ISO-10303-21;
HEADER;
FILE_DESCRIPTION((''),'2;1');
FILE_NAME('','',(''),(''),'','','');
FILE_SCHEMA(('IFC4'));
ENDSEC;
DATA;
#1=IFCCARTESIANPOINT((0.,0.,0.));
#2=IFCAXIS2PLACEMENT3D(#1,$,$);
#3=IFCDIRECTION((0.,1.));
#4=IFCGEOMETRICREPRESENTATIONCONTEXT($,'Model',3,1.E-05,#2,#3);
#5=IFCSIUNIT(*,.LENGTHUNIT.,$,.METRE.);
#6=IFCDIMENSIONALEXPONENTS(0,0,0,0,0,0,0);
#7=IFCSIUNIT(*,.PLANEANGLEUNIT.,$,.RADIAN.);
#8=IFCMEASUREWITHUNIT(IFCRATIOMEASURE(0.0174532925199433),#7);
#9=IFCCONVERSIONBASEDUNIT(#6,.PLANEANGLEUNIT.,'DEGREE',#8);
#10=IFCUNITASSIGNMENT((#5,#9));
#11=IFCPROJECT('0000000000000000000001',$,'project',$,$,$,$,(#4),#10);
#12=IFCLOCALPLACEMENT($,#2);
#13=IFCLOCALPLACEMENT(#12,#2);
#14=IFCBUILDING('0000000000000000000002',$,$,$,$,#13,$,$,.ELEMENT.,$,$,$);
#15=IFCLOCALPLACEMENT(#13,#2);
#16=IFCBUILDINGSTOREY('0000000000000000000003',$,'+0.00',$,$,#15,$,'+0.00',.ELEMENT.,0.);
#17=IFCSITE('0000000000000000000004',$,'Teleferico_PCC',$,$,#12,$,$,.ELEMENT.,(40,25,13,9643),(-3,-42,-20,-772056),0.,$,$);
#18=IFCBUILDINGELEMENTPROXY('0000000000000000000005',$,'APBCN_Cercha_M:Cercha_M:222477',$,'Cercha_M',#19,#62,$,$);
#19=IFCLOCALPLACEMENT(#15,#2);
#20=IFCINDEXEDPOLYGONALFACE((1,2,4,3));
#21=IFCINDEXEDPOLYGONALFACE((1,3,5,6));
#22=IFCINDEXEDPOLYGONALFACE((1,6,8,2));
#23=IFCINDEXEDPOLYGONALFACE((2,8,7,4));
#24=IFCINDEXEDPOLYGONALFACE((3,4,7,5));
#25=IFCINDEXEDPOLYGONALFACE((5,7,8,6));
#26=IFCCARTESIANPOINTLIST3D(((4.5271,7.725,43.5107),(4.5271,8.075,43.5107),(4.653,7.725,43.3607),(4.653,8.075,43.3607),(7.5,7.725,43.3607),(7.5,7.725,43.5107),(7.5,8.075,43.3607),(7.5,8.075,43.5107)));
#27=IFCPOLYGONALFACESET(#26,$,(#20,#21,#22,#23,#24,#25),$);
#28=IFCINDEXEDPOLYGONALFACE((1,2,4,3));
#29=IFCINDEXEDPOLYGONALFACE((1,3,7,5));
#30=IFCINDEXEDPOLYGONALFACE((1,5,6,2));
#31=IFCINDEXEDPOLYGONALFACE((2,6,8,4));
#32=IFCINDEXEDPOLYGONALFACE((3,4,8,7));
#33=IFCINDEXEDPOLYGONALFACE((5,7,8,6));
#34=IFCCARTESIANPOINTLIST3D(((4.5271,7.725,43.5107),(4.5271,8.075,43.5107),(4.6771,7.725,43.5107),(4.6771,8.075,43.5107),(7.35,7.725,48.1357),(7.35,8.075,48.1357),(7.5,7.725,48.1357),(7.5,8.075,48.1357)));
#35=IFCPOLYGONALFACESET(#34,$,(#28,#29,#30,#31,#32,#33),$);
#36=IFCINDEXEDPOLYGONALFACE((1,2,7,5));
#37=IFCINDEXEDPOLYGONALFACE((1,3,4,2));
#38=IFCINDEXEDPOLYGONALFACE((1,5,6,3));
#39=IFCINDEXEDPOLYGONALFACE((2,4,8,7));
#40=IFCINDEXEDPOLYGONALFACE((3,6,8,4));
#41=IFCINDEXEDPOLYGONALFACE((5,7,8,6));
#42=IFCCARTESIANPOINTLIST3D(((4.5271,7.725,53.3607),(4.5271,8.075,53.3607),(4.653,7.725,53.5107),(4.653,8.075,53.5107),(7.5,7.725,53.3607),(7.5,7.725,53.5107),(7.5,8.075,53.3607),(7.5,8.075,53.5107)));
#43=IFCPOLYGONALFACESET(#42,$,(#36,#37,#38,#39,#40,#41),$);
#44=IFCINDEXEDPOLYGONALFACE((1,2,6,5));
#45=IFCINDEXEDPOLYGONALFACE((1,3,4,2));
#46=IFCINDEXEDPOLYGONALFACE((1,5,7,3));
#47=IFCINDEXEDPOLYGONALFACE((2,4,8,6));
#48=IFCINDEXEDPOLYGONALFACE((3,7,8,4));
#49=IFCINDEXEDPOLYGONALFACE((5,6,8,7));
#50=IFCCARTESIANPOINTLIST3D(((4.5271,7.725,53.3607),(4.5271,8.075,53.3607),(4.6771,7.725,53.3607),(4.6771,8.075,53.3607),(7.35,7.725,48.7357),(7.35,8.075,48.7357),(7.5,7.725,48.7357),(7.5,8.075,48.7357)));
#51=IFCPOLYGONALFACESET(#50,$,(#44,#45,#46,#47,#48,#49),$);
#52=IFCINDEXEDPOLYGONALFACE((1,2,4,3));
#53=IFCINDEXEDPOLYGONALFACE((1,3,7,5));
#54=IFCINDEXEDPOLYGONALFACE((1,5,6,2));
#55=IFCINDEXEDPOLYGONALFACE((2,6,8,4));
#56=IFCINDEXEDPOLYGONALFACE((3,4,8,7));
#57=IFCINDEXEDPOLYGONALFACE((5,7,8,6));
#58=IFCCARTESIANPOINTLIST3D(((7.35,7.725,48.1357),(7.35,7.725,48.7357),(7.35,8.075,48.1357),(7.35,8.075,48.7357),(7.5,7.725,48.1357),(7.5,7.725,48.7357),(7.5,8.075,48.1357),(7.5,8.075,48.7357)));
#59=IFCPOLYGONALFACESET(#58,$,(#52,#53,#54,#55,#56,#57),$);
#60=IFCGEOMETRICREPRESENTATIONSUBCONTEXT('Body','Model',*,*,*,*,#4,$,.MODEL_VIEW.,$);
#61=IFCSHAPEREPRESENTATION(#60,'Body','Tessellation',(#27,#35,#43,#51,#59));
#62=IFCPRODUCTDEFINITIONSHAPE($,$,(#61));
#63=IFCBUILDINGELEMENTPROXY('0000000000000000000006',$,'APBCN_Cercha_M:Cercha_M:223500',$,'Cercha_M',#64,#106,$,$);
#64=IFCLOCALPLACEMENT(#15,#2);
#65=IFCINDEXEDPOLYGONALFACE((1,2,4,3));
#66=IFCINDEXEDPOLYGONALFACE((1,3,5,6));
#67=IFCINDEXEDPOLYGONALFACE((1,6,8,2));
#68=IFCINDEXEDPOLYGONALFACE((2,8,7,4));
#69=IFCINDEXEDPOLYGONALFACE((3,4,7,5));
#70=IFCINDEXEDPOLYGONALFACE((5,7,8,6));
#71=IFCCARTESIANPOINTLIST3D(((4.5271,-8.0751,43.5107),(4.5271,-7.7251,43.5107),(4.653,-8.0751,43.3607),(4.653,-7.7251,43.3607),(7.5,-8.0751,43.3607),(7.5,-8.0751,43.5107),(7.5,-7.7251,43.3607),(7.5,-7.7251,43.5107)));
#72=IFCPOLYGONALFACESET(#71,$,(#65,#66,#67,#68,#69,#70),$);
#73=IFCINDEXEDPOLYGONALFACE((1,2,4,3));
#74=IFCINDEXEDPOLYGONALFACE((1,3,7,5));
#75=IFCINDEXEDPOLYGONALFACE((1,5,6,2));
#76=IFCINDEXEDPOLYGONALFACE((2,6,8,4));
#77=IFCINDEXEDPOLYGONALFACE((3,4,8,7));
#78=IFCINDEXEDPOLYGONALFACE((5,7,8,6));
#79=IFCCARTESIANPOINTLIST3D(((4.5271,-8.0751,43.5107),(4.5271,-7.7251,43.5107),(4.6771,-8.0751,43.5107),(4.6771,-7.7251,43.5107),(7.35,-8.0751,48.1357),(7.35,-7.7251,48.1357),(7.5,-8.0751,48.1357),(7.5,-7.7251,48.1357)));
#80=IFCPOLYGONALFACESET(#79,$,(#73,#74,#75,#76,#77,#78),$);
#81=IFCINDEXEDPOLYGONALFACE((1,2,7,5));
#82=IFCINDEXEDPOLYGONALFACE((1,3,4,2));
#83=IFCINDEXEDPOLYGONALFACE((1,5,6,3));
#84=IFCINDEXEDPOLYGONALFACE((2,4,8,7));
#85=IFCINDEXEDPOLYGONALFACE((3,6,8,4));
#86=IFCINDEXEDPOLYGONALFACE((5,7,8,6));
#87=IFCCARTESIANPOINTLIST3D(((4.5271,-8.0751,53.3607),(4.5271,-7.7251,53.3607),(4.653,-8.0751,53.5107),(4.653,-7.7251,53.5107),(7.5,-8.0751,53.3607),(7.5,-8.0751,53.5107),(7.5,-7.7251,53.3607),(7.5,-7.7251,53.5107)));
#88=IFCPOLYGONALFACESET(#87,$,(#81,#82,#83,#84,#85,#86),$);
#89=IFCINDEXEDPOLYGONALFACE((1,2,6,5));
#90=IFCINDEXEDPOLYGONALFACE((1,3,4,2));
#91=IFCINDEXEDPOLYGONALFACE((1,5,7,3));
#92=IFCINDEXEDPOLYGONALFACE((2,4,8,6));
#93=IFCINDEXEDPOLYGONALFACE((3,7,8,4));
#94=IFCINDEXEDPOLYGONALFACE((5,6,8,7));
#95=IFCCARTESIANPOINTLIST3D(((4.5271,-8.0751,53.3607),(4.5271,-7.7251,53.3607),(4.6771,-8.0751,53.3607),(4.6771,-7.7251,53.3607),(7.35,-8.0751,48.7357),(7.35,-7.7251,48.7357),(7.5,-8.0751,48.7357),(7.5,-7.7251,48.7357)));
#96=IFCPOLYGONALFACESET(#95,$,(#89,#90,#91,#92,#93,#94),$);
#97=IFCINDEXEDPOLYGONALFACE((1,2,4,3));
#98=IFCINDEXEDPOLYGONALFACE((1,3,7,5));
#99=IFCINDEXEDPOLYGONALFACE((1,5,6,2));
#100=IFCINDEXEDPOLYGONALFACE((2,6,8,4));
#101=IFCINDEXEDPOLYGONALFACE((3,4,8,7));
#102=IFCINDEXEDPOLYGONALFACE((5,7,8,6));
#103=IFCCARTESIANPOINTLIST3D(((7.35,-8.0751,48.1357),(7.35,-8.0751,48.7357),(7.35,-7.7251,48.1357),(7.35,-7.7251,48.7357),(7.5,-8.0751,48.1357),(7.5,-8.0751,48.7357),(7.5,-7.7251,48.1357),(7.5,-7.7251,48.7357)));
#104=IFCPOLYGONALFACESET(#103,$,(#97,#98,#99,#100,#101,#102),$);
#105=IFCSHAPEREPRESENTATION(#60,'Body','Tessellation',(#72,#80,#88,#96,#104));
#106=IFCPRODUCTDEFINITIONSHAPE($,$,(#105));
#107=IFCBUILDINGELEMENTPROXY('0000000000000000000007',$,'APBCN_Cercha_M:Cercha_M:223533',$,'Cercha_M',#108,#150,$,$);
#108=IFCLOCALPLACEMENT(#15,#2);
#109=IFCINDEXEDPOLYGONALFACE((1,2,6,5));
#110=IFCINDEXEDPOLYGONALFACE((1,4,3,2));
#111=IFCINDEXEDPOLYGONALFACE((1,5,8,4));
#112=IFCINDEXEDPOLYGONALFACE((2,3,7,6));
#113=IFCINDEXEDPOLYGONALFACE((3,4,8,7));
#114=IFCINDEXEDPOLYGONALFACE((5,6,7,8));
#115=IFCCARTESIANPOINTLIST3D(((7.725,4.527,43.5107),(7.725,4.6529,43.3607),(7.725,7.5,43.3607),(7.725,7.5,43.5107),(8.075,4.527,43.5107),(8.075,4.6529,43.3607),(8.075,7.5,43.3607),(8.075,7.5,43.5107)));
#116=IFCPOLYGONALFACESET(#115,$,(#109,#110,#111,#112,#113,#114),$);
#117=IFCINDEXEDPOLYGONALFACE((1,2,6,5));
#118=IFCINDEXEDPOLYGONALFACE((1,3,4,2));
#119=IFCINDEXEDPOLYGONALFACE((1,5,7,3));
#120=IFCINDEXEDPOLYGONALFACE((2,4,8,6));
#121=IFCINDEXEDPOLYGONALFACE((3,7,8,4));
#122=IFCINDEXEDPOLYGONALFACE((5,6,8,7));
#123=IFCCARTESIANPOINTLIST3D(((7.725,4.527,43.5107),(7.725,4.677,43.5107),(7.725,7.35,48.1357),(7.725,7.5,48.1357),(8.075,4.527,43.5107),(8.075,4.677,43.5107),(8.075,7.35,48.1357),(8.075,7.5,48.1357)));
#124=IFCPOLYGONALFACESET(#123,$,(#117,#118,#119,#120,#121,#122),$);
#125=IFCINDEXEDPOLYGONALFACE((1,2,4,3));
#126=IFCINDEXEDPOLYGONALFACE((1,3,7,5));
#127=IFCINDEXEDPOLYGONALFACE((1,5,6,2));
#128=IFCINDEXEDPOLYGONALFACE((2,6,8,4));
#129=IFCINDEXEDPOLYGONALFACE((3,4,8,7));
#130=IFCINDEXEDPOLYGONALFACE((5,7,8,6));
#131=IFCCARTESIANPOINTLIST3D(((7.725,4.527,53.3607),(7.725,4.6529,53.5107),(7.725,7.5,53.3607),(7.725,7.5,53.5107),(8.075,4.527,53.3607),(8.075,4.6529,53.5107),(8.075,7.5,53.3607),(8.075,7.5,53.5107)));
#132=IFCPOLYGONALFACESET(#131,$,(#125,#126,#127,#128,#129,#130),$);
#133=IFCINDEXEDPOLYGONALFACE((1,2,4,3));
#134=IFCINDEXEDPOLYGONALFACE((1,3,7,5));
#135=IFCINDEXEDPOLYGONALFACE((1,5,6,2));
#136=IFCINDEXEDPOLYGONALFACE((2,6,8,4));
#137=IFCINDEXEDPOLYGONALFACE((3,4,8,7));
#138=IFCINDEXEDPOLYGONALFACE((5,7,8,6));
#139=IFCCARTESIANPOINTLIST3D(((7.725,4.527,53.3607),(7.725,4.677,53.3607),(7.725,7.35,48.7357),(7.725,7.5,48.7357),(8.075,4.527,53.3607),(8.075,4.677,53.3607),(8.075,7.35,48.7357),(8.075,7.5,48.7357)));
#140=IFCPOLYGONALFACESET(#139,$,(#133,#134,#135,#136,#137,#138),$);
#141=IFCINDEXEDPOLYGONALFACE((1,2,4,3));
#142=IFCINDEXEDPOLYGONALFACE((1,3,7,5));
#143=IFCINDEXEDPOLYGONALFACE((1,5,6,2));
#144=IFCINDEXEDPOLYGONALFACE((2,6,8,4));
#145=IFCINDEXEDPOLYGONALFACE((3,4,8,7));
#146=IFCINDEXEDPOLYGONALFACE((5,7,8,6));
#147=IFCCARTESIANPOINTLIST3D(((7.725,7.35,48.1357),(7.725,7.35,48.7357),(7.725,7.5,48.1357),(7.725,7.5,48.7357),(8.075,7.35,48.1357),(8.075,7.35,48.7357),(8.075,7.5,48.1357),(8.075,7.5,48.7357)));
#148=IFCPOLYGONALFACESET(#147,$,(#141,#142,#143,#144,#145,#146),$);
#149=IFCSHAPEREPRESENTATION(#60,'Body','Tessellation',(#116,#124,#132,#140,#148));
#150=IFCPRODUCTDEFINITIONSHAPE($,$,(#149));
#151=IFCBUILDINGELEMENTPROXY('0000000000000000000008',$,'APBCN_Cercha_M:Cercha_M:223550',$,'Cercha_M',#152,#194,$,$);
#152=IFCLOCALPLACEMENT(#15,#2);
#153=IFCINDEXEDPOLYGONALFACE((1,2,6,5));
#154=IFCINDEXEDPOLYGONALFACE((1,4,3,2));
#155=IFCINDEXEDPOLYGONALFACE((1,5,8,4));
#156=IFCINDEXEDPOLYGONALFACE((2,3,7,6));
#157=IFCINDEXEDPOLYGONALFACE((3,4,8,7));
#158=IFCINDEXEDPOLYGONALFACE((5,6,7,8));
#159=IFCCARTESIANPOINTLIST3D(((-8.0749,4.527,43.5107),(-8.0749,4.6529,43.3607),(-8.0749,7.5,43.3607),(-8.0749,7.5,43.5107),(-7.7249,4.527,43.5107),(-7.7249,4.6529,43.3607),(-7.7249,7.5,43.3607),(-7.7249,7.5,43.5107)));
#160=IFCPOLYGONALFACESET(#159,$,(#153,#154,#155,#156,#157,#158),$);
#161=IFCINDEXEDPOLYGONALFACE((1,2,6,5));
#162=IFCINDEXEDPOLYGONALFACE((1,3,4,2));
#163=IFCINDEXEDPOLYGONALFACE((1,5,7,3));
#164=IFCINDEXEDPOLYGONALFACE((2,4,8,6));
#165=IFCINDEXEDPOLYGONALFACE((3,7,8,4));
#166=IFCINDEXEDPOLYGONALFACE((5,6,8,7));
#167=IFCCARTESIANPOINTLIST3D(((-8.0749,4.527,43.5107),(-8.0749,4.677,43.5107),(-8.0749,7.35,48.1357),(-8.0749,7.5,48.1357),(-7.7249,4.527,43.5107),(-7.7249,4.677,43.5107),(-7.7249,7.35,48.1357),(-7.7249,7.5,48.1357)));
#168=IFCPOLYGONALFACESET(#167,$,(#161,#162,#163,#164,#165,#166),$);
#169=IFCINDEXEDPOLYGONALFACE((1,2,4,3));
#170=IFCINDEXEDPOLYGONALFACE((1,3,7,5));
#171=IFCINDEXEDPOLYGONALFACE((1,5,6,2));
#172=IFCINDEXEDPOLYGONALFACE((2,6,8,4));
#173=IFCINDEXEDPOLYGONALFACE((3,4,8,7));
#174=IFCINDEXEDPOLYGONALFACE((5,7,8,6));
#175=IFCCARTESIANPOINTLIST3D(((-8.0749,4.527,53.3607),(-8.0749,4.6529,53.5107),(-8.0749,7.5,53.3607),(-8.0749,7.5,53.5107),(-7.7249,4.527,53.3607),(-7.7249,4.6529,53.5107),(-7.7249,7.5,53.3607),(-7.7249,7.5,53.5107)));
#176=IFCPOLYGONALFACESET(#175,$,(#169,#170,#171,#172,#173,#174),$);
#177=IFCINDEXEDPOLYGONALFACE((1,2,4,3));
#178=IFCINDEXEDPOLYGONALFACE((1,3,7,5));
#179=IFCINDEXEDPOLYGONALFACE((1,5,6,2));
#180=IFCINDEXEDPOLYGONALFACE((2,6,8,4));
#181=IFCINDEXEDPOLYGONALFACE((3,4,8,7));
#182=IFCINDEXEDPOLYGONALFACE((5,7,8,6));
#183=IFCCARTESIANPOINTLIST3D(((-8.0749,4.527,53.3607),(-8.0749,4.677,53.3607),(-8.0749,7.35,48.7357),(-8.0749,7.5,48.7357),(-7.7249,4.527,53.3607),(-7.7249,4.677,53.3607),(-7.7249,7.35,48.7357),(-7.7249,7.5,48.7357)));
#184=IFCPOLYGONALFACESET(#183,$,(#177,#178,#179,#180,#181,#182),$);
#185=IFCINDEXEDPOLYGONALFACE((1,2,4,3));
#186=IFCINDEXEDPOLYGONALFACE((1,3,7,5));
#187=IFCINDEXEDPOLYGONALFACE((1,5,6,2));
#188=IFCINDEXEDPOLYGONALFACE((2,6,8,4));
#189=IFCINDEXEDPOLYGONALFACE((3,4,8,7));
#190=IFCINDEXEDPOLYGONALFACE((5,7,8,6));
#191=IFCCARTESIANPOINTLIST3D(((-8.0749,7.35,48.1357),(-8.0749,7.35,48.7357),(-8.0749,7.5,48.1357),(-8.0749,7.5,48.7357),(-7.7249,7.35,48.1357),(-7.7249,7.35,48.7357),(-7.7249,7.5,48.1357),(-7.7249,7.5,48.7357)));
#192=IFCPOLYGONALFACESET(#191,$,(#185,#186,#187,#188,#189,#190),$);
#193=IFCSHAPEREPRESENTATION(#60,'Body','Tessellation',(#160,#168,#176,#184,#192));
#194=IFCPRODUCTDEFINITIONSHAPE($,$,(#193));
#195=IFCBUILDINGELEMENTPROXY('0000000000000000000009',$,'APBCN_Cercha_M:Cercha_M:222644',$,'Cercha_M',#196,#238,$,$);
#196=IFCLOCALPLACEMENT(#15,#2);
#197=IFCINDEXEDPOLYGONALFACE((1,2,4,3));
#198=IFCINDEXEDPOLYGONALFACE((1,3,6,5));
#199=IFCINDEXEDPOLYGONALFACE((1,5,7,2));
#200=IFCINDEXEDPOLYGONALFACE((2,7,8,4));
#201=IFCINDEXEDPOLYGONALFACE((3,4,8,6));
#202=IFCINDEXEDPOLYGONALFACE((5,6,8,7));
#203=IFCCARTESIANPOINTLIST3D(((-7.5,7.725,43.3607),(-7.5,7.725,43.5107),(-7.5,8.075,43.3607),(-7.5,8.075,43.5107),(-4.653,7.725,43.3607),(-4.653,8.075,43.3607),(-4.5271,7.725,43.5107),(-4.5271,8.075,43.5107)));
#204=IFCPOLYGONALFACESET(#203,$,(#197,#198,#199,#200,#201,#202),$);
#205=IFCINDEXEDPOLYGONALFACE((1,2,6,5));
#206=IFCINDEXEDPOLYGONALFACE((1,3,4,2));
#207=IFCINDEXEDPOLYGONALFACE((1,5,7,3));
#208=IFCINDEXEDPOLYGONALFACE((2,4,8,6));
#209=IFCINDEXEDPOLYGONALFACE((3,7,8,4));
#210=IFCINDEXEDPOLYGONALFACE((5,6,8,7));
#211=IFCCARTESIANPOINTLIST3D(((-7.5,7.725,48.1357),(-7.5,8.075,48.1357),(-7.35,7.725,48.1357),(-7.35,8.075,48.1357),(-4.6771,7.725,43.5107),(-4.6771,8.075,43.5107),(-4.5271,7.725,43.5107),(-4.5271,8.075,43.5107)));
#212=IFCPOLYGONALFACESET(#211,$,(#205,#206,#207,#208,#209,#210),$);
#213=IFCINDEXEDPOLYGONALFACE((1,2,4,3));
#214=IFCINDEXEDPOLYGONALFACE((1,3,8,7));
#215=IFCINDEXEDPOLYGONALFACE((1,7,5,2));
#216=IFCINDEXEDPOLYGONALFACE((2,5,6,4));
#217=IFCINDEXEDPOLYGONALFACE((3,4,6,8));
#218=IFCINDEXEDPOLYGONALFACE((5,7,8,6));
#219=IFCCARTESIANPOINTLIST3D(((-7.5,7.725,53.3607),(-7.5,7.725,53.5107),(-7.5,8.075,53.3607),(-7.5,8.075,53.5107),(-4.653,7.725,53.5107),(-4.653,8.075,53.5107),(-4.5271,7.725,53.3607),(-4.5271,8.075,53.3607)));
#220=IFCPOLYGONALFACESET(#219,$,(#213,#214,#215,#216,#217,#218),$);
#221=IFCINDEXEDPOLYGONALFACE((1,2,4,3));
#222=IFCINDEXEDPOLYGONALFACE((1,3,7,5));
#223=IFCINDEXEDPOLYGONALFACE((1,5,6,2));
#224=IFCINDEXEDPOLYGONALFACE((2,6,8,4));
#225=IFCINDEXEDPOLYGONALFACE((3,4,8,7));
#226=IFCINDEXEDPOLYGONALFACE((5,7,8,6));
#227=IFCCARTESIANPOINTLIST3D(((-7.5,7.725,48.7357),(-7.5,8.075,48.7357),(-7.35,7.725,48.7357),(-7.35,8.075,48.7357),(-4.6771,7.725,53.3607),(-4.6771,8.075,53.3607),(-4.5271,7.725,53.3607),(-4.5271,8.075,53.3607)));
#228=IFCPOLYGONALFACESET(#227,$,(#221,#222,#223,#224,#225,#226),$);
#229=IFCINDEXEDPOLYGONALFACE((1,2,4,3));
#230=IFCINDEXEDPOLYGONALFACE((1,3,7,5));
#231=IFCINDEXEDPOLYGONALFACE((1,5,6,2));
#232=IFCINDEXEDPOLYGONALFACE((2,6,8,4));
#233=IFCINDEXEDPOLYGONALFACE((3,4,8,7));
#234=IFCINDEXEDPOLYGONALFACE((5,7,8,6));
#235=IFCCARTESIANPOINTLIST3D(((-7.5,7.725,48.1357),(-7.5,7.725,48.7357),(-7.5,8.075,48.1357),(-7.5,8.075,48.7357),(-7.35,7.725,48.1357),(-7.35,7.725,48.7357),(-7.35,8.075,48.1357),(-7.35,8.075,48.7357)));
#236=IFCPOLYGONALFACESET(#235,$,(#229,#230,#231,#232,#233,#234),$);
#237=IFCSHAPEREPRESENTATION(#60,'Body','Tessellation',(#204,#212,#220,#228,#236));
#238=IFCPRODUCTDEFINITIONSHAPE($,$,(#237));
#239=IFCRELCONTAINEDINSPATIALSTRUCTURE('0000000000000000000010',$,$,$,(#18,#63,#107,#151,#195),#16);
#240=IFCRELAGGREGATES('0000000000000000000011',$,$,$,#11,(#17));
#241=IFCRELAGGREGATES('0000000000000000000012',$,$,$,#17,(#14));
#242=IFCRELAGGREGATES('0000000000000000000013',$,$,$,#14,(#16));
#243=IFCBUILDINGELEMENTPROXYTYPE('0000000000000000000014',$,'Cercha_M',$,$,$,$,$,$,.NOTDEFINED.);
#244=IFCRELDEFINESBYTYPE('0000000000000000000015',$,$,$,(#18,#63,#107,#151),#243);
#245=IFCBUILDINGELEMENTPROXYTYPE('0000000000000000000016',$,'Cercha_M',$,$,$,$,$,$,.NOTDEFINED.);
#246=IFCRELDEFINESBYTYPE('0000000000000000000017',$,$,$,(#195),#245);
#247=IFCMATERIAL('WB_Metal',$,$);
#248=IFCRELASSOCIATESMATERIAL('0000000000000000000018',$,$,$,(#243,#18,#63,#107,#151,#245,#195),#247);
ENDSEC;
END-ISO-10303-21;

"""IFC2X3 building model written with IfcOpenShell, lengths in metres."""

from ifc_helpers import new_model, entity, si_unit, converted_unit, direction, frame, origin, origin_2d_with_axis, place, context, subcontext, project, spatial, polyline, rectangle, outline, extrude, source, transform, mapped, material, type_object, type_shapes, element, save


model = new_model("IFC2X3")

# Units and contexts
model_context = context("Model", 3, precision=1e-05, world=origin(), true_north=direction((0.0, 1.0)))
body_context = subcontext(model_context, "Body", "Model", "MODEL_VIEW")
ifc_project = project(units=[si_unit("LENGTHUNIT", "METRE"), converted_unit("PLANEANGLEUNIT", "DEGREE", entity("IfcRatioMeasure", 0.0174532925199433), si_unit("PLANEANGLEUNIT", "RADIAN"), dimensions=[0, 0, 0, 0, 0, 0, 0])], contexts=[model_context])

# Site, building, storey
site_placement = place(None, origin())
site = spatial("IfcSite", under=ifc_project, at=site_placement, Name="Teleferico_PCC", CompositionType="ELEMENT", RefLatitude=(40, 25, 13, 9643), RefLongitude=(-3, -42, -20, -772056), RefElevation=0.0)
building_placement = place(site_placement, origin())
building = spatial("IfcBuilding", under=site, at=building_placement, CompositionType="ELEMENT")
storey_placement = place(building_placement, origin())
storey = spatial("IfcBuildingStorey", under=building, at=storey_placement, Name="+0.00", LongName="+0.00", CompositionType="ELEMENT", Elevation=0.0)

# Shared definitions
ifc_material_1 = material(Name="WB_Metal")

# Building element proxies
building_element_proxy_type_1 = type_object("IfcBuildingElementProxyType", Name="Cercha_M", PredefinedType="NOTDEFINED", material=ifc_material_1)
shared_shape_1 = source(origin(), body_context, "Body", "SweptSolid", [
    extrude(outline(polyline([(-1.455, -0.075), (1.3921, -0.075), (1.5179, 0.075), (-1.455, 0.075), (-1.455, -0.075)])), frame((-1.455, -0.175, -5.0), z_axis=(0.0, 1.0, 0.0), x_axis=(-1.0, 0.0, 0.0)), (0.0, 0.0, 1.0), 0.35),
    extrude(outline(polyline([(1.3365, -2.3125), (1.4865, -2.3125), (-1.3365, 2.3125), (-1.4865, 2.3125), (1.3365, -2.3125)])), frame((-1.4865, -0.175, -2.6125), z_axis=(0.0, 1.0, 0.0), x_axis=(1.0, 0.0, 0.0)), (0.0, 0.0, 1.0), 0.35),
    extrude(outline(polyline([(-1.455, -0.075), (1.5179, -0.075), (1.3921, 0.075), (-1.455, 0.075), (-1.455, -0.075)])), frame((-1.455, -0.175, 5.0), z_axis=(0.0, 1.0, 0.0), x_axis=(-1.0, 0.0, 0.0)), (0.0, 0.0, 1.0), 0.35),
    extrude(outline(polyline([(-2.6701, -0.064), (2.7483, -0.064), (2.6701, 0.064), (-2.7483, 0.064), (-2.6701, -0.064)])), frame((-1.4865, -0.175, 2.6125), z_axis=(0.0, 1.0, 0.0), x_axis=(-0.520985, 0.0, 0.853566)), (0.0, 0.0, 1.0), 0.35),
    extrude(rectangle(XDim=0.35, YDim=0.15, at=origin_2d_with_axis()), frame((-0.075, 0.0, -0.3), z_axis=(0.0, 0.0, 1.0), x_axis=(0.0, 1.0, 0.0)), (0.0, 0.0, 1.0), 0.6),
])
type_shapes(building_element_proxy_type_1, [shared_shape_1])
for number, where, name in (
    (1, (7.5, 7.9, 48.4357), "APBCN_Cercha_M:Cercha_M:222477"),
    (2, (7.5, -7.9001, 48.4357), "APBCN_Cercha_M:Cercha_M:223500"),
):
    element("IfcBuildingElementProxy", number, at=place(storey_placement, frame(where)), inside=storey, type_object=building_element_proxy_type_1, material=ifc_material_1, Name=name, ObjectType="Cercha_M", context=body_context, shape_type="MappedRepresentation", body=[
        mapped(shared_shape_1, transform((0.0, 0.0, 0.0), scale=1.0)),
    ])
for number, where, z_axis, x_axis, name in (
    (3, (7.9, 7.5, 48.4357), (0.0, 0.0, 1.0), (0.0, 1.0, 0.0), "APBCN_Cercha_M:Cercha_M:223533"),
    (4, (-7.8999, 7.5, 48.4357), (0.0, 0.0, 1.0), (0.0, 1.0, 0.0), "APBCN_Cercha_M:Cercha_M:223550"),
):
    element("IfcBuildingElementProxy", number, at=place(storey_placement, frame(where, z_axis=z_axis, x_axis=x_axis)), inside=storey, type_object=building_element_proxy_type_1, material=ifc_material_1, Name=name, ObjectType="Cercha_M", context=body_context, shape_type="MappedRepresentation", body=[
        mapped(shared_shape_1, transform((0.0, 0.0, 0.0), scale=1.0)),
    ])
building_element_proxy_type_2 = type_object("IfcBuildingElementProxyType", Name="Cercha_M", PredefinedType="NOTDEFINED", material=ifc_material_1)
shared_shape_2 = source(origin(), body_context, "Body", "SweptSolid", [
    extrude(outline(polyline([(-0.075, -1.455), (0.075, -1.455), (0.075, 1.3921), (-0.075, 1.5179), (-0.075, -1.455)])), frame((-1.455, -0.175, -5.0), z_axis=(0.0, 1.0, 0.0), x_axis=(0.0, 0.0, -1.0)), (0.0, 0.0, 1.0), 0.35),
    extrude(outline(polyline([(1.3365, -2.3125), (1.4865, -2.3125), (-1.3365, 2.3125), (-1.4865, 2.3125), (1.3365, -2.3125)])), frame((-1.4865, -0.175, -2.6125), z_axis=(0.0, 1.0, 0.0), x_axis=(1.0, 0.0, 0.0)), (0.0, 0.0, 1.0), 0.35),
    extrude(outline(polyline([(-0.075, -1.455), (0.075, -1.455), (0.075, 1.5179), (-0.075, 1.3921), (-0.075, -1.455)])), frame((-1.455, -0.175, 5.0), z_axis=(0.0, 1.0, 0.0), x_axis=(0.0, 0.0, -1.0)), (0.0, 0.0, 1.0), 0.35),
    extrude(outline(polyline([(-2.6701, -0.064), (2.7483, -0.064), (2.6701, 0.064), (-2.7483, 0.064), (-2.6701, -0.064)])), frame((-1.4865, -0.175, 2.6125), z_axis=(0.0, 1.0, 0.0), x_axis=(-0.520985, 0.0, 0.853566)), (0.0, 0.0, 1.0), 0.35),
    extrude(rectangle(XDim=0.15, YDim=0.35, at=origin_2d_with_axis()), frame((-0.075, 0.0, -0.3), z_axis=(0.0, 0.0, 1.0), x_axis=(-1.0, 0.0, 0.0)), (0.0, 0.0, 1.0), 0.6),
])
type_shapes(building_element_proxy_type_2, [shared_shape_2])
for number, where, z_axis, x_axis, name in (
    (5, (-7.5, 7.9, 48.4357), (0.0, 0.0, 1.0), (-1.0, 0.0, 0.0), "APBCN_Cercha_M:Cercha_M:222644"),
):
    element("IfcBuildingElementProxy", number, at=place(storey_placement, frame(where, z_axis=z_axis, x_axis=x_axis)), inside=storey, type_object=building_element_proxy_type_2, material=ifc_material_1, Name=name, ObjectType="Cercha_M", context=body_context, shape_type="MappedRepresentation", body=[
        mapped(shared_shape_2, transform((0.0, 0.0, 0.0), scale=1.0)),
    ])

save(model, "model.ifc")
